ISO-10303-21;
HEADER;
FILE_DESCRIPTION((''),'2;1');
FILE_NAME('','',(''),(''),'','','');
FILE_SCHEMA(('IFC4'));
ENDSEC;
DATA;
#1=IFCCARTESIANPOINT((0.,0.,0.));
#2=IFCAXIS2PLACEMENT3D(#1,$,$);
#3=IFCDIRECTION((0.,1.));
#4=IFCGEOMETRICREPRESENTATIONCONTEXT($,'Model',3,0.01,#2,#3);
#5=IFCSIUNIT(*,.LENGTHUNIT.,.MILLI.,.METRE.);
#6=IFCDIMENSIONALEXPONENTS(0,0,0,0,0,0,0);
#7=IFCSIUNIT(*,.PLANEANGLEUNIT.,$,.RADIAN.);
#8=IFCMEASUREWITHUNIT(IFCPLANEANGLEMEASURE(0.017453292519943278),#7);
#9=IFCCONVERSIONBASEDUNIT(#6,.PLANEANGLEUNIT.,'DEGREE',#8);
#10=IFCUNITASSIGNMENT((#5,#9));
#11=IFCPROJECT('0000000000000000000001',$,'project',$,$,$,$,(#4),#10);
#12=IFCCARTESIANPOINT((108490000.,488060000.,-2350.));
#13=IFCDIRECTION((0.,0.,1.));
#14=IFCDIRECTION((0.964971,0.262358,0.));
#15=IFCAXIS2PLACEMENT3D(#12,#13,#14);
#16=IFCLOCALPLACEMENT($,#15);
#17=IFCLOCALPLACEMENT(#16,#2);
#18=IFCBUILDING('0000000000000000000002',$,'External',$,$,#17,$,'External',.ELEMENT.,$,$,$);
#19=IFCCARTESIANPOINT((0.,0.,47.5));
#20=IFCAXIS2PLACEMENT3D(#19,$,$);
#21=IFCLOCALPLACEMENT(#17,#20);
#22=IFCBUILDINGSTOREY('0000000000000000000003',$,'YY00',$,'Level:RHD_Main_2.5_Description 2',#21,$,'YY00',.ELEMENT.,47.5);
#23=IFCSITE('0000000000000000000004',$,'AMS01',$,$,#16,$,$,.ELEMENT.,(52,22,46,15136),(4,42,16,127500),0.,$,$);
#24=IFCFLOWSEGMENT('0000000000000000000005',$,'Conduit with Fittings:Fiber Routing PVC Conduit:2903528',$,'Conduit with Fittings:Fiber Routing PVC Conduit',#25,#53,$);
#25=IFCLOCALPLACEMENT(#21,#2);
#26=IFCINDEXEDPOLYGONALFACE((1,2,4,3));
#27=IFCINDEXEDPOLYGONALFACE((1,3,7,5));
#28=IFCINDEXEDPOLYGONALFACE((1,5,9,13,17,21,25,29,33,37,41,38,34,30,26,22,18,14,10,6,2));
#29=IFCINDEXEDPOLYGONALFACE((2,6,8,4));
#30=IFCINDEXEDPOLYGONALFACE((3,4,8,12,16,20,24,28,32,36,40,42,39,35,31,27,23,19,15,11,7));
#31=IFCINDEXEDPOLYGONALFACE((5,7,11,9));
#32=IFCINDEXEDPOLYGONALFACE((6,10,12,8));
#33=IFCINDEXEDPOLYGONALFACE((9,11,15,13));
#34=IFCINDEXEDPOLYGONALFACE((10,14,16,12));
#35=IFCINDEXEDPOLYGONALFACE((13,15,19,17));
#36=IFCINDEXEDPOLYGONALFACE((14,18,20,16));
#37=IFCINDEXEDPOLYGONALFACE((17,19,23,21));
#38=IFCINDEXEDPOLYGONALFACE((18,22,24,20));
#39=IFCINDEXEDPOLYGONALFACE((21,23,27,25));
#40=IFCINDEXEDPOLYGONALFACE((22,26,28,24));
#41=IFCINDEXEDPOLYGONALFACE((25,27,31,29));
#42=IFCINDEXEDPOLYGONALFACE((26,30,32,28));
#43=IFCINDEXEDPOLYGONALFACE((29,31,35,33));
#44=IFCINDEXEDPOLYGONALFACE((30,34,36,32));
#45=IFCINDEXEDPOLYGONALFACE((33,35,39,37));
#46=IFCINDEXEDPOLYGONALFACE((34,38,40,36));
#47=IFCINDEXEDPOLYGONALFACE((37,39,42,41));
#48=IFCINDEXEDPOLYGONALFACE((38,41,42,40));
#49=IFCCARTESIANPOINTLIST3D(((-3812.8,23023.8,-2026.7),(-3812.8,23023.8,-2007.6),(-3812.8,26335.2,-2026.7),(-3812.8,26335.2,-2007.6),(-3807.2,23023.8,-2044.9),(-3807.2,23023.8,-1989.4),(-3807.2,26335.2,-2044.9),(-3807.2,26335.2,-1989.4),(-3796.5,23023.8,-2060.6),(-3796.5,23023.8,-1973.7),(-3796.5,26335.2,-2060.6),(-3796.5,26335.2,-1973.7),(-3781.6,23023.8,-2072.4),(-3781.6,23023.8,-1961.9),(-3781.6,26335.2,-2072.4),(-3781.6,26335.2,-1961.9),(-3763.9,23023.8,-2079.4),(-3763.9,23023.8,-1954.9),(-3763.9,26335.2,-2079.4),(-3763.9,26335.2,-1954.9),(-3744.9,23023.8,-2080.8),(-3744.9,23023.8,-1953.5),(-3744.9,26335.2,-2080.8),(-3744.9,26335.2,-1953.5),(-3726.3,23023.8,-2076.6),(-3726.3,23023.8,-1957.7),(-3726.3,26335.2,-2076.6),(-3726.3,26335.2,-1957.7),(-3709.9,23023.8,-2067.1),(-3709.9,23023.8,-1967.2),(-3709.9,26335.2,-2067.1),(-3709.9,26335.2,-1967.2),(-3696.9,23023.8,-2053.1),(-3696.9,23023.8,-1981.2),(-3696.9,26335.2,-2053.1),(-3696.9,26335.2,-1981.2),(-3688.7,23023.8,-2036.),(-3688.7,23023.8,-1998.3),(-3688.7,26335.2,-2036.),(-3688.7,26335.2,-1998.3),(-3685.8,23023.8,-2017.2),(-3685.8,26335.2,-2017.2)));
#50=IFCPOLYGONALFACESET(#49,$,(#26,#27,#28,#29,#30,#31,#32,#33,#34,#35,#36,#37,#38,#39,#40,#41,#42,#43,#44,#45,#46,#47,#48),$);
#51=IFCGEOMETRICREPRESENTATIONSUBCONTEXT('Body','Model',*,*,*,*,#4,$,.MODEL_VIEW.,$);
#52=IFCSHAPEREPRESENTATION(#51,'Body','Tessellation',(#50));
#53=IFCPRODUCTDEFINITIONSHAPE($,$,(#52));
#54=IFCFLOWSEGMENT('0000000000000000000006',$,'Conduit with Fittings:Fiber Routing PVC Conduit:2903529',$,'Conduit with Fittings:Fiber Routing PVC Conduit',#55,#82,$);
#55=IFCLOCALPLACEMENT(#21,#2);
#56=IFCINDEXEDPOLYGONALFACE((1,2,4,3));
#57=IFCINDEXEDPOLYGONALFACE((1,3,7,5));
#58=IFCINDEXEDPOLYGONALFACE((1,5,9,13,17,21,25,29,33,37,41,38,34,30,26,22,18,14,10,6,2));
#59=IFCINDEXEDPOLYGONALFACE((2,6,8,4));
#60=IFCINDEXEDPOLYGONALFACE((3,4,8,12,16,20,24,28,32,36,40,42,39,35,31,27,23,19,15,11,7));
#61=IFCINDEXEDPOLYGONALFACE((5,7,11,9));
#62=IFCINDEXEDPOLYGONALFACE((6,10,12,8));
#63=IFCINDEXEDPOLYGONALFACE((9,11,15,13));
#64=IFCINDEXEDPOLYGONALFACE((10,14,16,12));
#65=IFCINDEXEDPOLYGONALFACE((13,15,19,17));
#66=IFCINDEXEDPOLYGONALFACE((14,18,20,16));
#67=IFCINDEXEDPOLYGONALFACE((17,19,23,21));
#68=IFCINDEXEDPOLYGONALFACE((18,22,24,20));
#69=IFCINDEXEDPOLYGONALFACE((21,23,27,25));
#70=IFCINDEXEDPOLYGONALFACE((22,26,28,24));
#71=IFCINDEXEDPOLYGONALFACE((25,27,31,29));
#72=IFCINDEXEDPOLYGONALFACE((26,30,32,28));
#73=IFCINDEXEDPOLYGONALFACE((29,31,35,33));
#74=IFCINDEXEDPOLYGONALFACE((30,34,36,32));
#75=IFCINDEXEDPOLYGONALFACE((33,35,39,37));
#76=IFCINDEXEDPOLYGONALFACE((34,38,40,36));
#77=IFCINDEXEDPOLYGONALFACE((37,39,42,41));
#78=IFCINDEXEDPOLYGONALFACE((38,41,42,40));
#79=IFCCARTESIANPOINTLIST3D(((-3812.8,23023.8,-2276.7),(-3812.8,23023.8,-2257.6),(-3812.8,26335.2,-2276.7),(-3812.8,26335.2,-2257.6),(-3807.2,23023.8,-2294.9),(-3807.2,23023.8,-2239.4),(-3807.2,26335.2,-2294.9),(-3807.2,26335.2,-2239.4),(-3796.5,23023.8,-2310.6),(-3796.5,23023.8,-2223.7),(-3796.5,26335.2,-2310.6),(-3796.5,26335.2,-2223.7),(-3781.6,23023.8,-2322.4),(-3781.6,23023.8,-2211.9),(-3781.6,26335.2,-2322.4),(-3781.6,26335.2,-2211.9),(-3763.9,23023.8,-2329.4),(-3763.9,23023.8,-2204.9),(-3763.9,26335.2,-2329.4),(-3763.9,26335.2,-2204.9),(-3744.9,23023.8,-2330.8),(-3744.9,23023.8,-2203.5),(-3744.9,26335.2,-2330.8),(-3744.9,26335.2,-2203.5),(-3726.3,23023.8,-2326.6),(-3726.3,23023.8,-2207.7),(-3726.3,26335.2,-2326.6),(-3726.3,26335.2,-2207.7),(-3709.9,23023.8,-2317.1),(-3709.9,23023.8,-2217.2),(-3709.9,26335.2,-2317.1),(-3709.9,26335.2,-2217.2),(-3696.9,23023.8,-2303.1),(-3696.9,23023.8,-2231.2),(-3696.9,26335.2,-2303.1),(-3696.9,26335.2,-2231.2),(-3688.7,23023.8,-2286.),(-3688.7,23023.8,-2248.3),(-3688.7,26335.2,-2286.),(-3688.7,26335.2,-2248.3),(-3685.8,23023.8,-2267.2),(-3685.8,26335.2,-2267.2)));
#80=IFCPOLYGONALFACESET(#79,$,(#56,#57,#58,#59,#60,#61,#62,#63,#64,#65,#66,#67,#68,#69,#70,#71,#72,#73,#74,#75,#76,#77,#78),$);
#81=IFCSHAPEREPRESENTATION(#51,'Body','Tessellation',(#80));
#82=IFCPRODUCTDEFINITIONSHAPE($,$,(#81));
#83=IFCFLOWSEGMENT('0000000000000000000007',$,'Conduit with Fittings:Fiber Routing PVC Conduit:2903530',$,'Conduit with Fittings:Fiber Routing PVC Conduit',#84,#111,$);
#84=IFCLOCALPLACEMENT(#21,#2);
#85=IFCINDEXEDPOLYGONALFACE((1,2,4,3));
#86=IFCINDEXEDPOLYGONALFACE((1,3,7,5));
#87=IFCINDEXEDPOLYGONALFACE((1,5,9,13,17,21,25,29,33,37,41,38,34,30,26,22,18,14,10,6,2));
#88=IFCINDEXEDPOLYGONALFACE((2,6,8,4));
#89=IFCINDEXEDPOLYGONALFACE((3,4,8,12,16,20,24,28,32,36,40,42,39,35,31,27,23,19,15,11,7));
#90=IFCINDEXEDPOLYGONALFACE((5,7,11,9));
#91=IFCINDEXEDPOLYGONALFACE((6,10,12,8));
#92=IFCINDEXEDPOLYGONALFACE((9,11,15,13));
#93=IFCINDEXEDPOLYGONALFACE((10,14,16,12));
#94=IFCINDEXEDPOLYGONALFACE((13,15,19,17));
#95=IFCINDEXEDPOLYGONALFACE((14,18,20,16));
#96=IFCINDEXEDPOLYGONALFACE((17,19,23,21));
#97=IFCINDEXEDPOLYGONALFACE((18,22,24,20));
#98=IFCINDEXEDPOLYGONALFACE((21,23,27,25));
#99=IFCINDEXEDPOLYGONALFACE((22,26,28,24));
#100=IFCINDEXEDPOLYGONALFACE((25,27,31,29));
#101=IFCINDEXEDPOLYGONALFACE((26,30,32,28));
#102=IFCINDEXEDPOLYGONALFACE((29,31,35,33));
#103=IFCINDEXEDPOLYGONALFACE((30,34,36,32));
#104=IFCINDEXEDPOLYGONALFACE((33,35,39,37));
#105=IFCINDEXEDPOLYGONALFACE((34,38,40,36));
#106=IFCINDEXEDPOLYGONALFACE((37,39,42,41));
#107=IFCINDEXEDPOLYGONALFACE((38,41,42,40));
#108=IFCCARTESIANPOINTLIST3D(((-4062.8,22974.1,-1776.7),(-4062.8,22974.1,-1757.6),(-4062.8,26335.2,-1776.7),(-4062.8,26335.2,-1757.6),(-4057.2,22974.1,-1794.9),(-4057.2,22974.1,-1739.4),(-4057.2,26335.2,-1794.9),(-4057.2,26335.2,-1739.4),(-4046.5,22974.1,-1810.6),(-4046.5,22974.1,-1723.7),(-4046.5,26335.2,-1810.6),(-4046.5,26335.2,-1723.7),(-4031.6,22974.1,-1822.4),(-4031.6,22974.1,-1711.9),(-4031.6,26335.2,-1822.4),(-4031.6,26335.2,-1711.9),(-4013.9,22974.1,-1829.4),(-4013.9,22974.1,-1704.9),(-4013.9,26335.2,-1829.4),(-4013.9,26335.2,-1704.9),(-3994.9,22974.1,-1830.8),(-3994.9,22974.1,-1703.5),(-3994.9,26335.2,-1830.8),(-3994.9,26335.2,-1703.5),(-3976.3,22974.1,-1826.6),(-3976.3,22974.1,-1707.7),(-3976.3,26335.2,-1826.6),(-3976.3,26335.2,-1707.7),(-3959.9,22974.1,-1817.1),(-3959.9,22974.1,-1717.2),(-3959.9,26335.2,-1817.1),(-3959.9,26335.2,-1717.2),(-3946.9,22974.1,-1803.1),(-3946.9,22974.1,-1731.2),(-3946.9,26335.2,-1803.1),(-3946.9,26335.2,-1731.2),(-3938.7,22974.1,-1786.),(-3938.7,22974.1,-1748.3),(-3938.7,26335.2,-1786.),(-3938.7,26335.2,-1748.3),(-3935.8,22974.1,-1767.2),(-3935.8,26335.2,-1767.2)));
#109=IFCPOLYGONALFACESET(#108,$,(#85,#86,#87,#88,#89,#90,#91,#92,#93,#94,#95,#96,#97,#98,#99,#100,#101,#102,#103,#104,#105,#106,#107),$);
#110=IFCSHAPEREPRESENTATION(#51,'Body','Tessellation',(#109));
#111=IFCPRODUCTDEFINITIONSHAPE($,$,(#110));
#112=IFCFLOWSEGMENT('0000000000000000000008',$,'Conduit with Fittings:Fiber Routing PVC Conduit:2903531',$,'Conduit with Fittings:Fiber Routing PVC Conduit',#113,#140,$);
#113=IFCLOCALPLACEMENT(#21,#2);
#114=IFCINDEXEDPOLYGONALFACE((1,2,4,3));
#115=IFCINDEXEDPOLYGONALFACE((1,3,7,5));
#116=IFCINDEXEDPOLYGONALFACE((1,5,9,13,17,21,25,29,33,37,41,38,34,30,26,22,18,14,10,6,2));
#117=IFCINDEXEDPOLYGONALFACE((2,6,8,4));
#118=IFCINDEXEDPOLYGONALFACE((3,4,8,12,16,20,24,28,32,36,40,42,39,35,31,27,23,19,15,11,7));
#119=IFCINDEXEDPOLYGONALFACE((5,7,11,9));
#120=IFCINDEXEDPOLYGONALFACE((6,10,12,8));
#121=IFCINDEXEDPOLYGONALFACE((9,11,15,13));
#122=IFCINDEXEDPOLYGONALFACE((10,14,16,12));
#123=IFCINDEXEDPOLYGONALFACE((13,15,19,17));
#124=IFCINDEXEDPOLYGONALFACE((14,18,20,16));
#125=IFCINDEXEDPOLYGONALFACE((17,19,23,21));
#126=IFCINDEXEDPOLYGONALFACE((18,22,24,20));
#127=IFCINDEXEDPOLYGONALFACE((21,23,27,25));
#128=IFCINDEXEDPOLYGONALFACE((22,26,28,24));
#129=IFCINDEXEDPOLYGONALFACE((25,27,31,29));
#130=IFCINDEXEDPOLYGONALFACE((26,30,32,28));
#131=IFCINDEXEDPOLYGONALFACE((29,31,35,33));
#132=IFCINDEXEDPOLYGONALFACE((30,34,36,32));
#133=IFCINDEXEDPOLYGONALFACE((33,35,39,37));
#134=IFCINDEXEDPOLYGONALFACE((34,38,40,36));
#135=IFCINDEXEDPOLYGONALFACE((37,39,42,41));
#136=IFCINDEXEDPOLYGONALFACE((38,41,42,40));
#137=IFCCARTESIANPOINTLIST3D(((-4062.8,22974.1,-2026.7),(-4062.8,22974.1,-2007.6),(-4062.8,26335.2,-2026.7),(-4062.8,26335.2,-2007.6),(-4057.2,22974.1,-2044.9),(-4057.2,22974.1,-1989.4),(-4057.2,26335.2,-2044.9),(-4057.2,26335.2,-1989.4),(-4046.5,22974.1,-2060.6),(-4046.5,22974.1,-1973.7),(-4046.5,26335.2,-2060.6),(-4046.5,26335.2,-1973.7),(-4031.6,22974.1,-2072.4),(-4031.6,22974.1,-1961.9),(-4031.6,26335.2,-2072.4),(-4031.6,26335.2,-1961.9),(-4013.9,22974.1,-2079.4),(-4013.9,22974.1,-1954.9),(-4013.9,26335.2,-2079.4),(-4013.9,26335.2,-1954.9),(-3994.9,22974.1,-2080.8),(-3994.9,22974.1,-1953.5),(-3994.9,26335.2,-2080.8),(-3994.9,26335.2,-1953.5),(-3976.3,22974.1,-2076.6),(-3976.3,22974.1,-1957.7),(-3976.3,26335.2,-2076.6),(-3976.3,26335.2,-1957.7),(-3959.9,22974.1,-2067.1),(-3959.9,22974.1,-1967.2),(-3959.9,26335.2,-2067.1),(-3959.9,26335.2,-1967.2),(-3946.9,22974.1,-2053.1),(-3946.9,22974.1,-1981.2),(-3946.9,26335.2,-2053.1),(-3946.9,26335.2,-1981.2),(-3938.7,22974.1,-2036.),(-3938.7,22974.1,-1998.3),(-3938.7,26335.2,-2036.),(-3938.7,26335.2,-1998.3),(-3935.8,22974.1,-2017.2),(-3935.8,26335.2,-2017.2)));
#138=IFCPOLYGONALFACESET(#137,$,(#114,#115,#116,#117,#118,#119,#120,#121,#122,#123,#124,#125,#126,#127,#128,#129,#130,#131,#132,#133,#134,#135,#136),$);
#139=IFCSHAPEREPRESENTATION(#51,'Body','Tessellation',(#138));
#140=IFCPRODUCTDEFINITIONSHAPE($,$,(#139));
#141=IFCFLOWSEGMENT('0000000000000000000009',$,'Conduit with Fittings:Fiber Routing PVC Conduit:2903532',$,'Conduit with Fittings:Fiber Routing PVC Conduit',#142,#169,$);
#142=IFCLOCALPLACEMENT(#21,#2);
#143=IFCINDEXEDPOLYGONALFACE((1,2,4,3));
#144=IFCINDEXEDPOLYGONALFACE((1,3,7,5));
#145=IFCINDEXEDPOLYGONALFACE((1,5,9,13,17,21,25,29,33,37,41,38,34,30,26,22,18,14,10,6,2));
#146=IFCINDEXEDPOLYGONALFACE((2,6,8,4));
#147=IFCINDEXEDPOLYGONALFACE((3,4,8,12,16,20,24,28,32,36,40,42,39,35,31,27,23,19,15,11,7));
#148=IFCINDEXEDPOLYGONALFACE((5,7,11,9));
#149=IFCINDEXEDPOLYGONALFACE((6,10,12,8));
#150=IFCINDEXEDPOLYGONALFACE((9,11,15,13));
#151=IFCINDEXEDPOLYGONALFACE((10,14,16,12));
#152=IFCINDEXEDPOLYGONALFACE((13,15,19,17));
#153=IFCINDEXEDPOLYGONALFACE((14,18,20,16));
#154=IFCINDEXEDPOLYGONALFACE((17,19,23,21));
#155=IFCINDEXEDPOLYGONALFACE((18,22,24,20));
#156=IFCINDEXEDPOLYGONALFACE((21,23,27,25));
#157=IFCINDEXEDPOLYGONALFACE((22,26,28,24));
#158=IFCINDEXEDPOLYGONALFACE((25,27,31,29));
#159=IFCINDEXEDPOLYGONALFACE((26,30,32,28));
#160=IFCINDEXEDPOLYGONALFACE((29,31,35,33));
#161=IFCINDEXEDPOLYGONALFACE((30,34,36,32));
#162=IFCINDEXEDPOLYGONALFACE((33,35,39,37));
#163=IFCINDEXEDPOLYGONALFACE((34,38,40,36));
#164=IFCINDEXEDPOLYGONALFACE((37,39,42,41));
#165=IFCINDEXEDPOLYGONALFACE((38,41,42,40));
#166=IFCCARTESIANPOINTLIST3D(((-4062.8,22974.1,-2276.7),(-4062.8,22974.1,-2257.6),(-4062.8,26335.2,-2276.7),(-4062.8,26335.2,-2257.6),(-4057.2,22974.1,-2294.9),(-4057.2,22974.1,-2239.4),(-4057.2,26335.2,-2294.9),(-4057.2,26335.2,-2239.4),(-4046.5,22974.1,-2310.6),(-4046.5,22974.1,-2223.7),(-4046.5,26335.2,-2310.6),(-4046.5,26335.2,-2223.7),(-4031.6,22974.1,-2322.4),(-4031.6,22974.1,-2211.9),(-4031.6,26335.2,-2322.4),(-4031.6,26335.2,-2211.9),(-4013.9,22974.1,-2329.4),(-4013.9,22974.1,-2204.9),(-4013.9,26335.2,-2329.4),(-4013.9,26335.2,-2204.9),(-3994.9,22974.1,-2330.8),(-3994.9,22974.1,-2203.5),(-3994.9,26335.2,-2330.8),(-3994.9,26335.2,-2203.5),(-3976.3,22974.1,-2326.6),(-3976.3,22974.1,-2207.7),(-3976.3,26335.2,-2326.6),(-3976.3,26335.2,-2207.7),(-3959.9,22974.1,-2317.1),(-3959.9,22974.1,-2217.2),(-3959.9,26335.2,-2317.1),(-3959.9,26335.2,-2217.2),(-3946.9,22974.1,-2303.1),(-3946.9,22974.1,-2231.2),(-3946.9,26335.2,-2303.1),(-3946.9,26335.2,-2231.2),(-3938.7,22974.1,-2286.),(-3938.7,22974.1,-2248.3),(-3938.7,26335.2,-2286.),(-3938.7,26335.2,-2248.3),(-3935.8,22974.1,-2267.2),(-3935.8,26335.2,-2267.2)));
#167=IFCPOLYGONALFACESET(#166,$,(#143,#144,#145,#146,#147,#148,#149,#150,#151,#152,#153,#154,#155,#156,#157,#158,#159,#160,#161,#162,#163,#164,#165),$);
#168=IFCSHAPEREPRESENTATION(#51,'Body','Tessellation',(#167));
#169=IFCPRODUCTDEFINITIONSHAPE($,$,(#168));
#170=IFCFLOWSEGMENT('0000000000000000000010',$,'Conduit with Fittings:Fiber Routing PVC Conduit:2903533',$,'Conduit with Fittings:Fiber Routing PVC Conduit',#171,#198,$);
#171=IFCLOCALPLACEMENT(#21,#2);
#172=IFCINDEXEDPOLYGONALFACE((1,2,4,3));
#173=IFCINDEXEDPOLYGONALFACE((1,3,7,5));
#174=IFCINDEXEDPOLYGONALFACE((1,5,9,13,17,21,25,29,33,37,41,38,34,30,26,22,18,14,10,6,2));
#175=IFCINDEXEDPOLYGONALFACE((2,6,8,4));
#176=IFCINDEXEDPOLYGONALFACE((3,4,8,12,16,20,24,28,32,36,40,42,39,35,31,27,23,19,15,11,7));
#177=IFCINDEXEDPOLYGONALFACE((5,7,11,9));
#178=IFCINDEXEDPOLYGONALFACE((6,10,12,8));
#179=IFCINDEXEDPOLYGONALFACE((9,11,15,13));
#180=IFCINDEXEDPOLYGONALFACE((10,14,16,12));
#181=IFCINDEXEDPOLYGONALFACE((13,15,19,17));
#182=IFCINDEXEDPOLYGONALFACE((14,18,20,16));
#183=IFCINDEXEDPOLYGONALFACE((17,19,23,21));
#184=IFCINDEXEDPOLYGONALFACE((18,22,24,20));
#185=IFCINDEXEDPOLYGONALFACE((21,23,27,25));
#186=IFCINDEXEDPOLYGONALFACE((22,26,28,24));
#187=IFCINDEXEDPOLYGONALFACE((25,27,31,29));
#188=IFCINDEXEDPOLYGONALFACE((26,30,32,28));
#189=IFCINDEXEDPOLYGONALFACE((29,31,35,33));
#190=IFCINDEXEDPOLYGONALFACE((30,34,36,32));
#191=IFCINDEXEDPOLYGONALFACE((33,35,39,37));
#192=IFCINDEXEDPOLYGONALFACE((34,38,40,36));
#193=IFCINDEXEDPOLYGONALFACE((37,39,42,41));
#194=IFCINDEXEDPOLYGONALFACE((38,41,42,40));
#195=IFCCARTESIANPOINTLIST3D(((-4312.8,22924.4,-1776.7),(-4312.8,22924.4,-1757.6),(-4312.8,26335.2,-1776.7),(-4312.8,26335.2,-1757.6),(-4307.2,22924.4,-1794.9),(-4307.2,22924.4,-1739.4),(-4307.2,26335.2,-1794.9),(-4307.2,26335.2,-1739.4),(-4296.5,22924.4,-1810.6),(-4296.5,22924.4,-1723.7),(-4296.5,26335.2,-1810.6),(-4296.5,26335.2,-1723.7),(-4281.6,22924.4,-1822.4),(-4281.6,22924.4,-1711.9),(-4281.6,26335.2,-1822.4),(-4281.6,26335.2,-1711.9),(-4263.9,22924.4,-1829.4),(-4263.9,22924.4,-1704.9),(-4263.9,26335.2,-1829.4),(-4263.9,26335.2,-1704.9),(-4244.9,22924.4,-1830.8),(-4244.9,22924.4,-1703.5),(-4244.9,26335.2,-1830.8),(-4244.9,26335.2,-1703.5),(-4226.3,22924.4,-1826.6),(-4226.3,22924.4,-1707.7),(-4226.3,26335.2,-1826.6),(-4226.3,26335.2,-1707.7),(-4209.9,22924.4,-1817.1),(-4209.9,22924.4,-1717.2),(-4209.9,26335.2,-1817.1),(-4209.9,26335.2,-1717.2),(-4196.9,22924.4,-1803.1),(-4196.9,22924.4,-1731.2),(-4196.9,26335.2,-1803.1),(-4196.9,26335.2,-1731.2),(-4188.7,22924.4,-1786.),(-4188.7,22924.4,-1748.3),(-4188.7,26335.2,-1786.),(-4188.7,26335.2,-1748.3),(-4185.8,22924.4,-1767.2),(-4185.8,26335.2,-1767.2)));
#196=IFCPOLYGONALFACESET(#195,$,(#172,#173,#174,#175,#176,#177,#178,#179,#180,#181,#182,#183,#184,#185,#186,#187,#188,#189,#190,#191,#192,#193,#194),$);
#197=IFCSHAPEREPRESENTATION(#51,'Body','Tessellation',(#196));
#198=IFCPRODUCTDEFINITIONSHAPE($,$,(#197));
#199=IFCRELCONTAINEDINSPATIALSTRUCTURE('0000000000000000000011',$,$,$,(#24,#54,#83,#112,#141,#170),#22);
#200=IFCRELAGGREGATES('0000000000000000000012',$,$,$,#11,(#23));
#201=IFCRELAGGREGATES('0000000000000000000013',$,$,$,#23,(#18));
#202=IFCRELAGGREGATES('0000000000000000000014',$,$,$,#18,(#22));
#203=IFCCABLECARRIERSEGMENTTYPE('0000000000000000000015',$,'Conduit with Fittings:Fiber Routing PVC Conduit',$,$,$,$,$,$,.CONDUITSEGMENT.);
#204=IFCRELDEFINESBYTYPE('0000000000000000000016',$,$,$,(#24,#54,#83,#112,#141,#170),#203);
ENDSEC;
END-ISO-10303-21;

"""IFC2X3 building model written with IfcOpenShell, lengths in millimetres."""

from ifc_helpers import new_model, entity, si_unit, converted_unit, direction, frame, frame_2d, origin, origin_2d_with_axis, place, context, subcontext, project, spatial, circle, extrude, type_object, element, save


model = new_model("IFC2X3")

# Units and contexts
model_context = context("Model", 3, precision=0.01, world=origin(), true_north=direction((0.0, 1.0)))
body_context = subcontext(model_context, "Body", "Model", "MODEL_VIEW")
ifc_project = project(units=[si_unit("LENGTHUNIT", "METRE", prefix="MILLI"), converted_unit("PLANEANGLEUNIT", "DEGREE", entity("IfcPlaneAngleMeasure", 0.017453292519943278), si_unit("PLANEANGLEUNIT", "RADIAN"), dimensions=[0, 0, 0, 0, 0, 0, 0])], contexts=[model_context])

# Site, building, storey
site_placement = place(None, frame((108490000.0, 488060000.0, -2350.0), z_axis=(0.0, 0.0, 1.0), x_axis=(0.964971, 0.262358, 0.0)))
site = spatial("IfcSite", under=ifc_project, at=site_placement, Name="AMS01", CompositionType="ELEMENT", RefLatitude=(52, 22, 46, 15136), RefLongitude=(4, 42, 16, 127500), RefElevation=0.0)
building_placement = place(site_placement, origin())
building = spatial("IfcBuilding", under=site, at=building_placement, Name="External", LongName="External", CompositionType="ELEMENT")
storey_placement = place(building_placement, frame((0.0, 0.0, 47.5)))
storey = spatial("IfcBuildingStorey", under=building, at=storey_placement, Name="YY00", ObjectType="Level:RHD_Main_2.5_Description 2", LongName="YY00", CompositionType="ELEMENT", Elevation=47.5)

# Flow segments
cable_carrier_segment_type = type_object("IfcCableCarrierSegmentType", Name="Conduit with Fittings:Fiber Routing PVC Conduit", PredefinedType="CONDUITSEGMENT")
flow_segment_1_placement = place(storey_placement, origin())
element("IfcFlowSegment", 1, at=flow_segment_1_placement, inside=storey, type_object=cable_carrier_segment_type, Name="Conduit with Fittings:Fiber Routing PVC Conduit:2903528", ObjectType="Conduit with Fittings:Fiber Routing PVC Conduit", context=body_context, shape_type="SweptSolid", body=[
    extrude(circle(Radius=63.9, at=frame_2d((0.0, 0.0), x_axis=(1.0, 0.0))), frame((-3749.7, 23023.8, -2017.2), z_axis=(0.0, 1.0, 0.0), x_axis=(1.0, 0.0, 0.0)), (0.0, 0.0, 1.0), 3311.4),
])
flow_segment_2_placement = place(storey_placement, origin())
element("IfcFlowSegment", 2, at=flow_segment_2_placement, inside=storey, type_object=cable_carrier_segment_type, Name="Conduit with Fittings:Fiber Routing PVC Conduit:2903529", ObjectType="Conduit with Fittings:Fiber Routing PVC Conduit", context=body_context, shape_type="SweptSolid", body=[
    extrude(circle(Radius=63.9, at=frame_2d((0.0, 0.0), x_axis=(1.0, 0.0))), frame((-3749.7, 23023.8, -2267.2), z_axis=(0.0, 1.0, 0.0), x_axis=(1.0, 0.0, 0.0)), (0.0, 0.0, 1.0), 3311.4),
])
flow_segment_3_placement = place(storey_placement, origin())
element("IfcFlowSegment", 3, at=flow_segment_3_placement, inside=storey, type_object=cable_carrier_segment_type, Name="Conduit with Fittings:Fiber Routing PVC Conduit:2903530", ObjectType="Conduit with Fittings:Fiber Routing PVC Conduit", context=body_context, shape_type="SweptSolid", body=[
    extrude(circle(Radius=63.9, at=frame_2d((0.0, 0.0), x_axis=(1.0, 0.0))), frame((-3999.7, 22974.1, -1767.2), z_axis=(0.0, 1.0, 0.0), x_axis=(1.0, 0.0, 0.0)), (0.0, 0.0, 1.0), 3361.1),
])
flow_segment_4_placement = place(storey_placement, origin())
element("IfcFlowSegment", 4, at=flow_segment_4_placement, inside=storey, type_object=cable_carrier_segment_type, Name="Conduit with Fittings:Fiber Routing PVC Conduit:2903531", ObjectType="Conduit with Fittings:Fiber Routing PVC Conduit", context=body_context, shape_type="SweptSolid", body=[
    extrude(circle(Radius=63.9, at=frame_2d((0.0, 0.0), x_axis=(1.0, 0.0))), frame((-3999.7, 22974.1, -2017.2), z_axis=(0.0, 1.0, 0.0), x_axis=(1.0, 0.0, 0.0)), (0.0, 0.0, 1.0), 3361.1),
])
flow_segment_5_placement = place(storey_placement, origin())
element("IfcFlowSegment", 5, at=flow_segment_5_placement, inside=storey, type_object=cable_carrier_segment_type, Name="Conduit with Fittings:Fiber Routing PVC Conduit:2903532", ObjectType="Conduit with Fittings:Fiber Routing PVC Conduit", context=body_context, shape_type="SweptSolid", body=[
    extrude(circle(Radius=63.9, at=frame_2d((0.0, 0.0), x_axis=(1.0, 0.0))), frame((-3999.7, 22974.1, -2267.2), z_axis=(0.0, 1.0, 0.0), x_axis=(1.0, 0.0, 0.0)), (0.0, 0.0, 1.0), 3361.1),
])
flow_segment_6_placement = place(storey_placement, origin())
element("IfcFlowSegment", 6, at=flow_segment_6_placement, inside=storey, type_object=cable_carrier_segment_type, Name="Conduit with Fittings:Fiber Routing PVC Conduit:2903533", ObjectType="Conduit with Fittings:Fiber Routing PVC Conduit", context=body_context, shape_type="SweptSolid", body=[
    extrude(circle(Radius=63.9, at=origin_2d_with_axis()), frame((-4249.7, 22924.4, -1767.2), z_axis=(0.0, 1.0, 0.0), x_axis=(1.0, 0.0, 0.0)), (0.0, 0.0, 1.0), 3410.8),
])

save(model, "model.ifc")
